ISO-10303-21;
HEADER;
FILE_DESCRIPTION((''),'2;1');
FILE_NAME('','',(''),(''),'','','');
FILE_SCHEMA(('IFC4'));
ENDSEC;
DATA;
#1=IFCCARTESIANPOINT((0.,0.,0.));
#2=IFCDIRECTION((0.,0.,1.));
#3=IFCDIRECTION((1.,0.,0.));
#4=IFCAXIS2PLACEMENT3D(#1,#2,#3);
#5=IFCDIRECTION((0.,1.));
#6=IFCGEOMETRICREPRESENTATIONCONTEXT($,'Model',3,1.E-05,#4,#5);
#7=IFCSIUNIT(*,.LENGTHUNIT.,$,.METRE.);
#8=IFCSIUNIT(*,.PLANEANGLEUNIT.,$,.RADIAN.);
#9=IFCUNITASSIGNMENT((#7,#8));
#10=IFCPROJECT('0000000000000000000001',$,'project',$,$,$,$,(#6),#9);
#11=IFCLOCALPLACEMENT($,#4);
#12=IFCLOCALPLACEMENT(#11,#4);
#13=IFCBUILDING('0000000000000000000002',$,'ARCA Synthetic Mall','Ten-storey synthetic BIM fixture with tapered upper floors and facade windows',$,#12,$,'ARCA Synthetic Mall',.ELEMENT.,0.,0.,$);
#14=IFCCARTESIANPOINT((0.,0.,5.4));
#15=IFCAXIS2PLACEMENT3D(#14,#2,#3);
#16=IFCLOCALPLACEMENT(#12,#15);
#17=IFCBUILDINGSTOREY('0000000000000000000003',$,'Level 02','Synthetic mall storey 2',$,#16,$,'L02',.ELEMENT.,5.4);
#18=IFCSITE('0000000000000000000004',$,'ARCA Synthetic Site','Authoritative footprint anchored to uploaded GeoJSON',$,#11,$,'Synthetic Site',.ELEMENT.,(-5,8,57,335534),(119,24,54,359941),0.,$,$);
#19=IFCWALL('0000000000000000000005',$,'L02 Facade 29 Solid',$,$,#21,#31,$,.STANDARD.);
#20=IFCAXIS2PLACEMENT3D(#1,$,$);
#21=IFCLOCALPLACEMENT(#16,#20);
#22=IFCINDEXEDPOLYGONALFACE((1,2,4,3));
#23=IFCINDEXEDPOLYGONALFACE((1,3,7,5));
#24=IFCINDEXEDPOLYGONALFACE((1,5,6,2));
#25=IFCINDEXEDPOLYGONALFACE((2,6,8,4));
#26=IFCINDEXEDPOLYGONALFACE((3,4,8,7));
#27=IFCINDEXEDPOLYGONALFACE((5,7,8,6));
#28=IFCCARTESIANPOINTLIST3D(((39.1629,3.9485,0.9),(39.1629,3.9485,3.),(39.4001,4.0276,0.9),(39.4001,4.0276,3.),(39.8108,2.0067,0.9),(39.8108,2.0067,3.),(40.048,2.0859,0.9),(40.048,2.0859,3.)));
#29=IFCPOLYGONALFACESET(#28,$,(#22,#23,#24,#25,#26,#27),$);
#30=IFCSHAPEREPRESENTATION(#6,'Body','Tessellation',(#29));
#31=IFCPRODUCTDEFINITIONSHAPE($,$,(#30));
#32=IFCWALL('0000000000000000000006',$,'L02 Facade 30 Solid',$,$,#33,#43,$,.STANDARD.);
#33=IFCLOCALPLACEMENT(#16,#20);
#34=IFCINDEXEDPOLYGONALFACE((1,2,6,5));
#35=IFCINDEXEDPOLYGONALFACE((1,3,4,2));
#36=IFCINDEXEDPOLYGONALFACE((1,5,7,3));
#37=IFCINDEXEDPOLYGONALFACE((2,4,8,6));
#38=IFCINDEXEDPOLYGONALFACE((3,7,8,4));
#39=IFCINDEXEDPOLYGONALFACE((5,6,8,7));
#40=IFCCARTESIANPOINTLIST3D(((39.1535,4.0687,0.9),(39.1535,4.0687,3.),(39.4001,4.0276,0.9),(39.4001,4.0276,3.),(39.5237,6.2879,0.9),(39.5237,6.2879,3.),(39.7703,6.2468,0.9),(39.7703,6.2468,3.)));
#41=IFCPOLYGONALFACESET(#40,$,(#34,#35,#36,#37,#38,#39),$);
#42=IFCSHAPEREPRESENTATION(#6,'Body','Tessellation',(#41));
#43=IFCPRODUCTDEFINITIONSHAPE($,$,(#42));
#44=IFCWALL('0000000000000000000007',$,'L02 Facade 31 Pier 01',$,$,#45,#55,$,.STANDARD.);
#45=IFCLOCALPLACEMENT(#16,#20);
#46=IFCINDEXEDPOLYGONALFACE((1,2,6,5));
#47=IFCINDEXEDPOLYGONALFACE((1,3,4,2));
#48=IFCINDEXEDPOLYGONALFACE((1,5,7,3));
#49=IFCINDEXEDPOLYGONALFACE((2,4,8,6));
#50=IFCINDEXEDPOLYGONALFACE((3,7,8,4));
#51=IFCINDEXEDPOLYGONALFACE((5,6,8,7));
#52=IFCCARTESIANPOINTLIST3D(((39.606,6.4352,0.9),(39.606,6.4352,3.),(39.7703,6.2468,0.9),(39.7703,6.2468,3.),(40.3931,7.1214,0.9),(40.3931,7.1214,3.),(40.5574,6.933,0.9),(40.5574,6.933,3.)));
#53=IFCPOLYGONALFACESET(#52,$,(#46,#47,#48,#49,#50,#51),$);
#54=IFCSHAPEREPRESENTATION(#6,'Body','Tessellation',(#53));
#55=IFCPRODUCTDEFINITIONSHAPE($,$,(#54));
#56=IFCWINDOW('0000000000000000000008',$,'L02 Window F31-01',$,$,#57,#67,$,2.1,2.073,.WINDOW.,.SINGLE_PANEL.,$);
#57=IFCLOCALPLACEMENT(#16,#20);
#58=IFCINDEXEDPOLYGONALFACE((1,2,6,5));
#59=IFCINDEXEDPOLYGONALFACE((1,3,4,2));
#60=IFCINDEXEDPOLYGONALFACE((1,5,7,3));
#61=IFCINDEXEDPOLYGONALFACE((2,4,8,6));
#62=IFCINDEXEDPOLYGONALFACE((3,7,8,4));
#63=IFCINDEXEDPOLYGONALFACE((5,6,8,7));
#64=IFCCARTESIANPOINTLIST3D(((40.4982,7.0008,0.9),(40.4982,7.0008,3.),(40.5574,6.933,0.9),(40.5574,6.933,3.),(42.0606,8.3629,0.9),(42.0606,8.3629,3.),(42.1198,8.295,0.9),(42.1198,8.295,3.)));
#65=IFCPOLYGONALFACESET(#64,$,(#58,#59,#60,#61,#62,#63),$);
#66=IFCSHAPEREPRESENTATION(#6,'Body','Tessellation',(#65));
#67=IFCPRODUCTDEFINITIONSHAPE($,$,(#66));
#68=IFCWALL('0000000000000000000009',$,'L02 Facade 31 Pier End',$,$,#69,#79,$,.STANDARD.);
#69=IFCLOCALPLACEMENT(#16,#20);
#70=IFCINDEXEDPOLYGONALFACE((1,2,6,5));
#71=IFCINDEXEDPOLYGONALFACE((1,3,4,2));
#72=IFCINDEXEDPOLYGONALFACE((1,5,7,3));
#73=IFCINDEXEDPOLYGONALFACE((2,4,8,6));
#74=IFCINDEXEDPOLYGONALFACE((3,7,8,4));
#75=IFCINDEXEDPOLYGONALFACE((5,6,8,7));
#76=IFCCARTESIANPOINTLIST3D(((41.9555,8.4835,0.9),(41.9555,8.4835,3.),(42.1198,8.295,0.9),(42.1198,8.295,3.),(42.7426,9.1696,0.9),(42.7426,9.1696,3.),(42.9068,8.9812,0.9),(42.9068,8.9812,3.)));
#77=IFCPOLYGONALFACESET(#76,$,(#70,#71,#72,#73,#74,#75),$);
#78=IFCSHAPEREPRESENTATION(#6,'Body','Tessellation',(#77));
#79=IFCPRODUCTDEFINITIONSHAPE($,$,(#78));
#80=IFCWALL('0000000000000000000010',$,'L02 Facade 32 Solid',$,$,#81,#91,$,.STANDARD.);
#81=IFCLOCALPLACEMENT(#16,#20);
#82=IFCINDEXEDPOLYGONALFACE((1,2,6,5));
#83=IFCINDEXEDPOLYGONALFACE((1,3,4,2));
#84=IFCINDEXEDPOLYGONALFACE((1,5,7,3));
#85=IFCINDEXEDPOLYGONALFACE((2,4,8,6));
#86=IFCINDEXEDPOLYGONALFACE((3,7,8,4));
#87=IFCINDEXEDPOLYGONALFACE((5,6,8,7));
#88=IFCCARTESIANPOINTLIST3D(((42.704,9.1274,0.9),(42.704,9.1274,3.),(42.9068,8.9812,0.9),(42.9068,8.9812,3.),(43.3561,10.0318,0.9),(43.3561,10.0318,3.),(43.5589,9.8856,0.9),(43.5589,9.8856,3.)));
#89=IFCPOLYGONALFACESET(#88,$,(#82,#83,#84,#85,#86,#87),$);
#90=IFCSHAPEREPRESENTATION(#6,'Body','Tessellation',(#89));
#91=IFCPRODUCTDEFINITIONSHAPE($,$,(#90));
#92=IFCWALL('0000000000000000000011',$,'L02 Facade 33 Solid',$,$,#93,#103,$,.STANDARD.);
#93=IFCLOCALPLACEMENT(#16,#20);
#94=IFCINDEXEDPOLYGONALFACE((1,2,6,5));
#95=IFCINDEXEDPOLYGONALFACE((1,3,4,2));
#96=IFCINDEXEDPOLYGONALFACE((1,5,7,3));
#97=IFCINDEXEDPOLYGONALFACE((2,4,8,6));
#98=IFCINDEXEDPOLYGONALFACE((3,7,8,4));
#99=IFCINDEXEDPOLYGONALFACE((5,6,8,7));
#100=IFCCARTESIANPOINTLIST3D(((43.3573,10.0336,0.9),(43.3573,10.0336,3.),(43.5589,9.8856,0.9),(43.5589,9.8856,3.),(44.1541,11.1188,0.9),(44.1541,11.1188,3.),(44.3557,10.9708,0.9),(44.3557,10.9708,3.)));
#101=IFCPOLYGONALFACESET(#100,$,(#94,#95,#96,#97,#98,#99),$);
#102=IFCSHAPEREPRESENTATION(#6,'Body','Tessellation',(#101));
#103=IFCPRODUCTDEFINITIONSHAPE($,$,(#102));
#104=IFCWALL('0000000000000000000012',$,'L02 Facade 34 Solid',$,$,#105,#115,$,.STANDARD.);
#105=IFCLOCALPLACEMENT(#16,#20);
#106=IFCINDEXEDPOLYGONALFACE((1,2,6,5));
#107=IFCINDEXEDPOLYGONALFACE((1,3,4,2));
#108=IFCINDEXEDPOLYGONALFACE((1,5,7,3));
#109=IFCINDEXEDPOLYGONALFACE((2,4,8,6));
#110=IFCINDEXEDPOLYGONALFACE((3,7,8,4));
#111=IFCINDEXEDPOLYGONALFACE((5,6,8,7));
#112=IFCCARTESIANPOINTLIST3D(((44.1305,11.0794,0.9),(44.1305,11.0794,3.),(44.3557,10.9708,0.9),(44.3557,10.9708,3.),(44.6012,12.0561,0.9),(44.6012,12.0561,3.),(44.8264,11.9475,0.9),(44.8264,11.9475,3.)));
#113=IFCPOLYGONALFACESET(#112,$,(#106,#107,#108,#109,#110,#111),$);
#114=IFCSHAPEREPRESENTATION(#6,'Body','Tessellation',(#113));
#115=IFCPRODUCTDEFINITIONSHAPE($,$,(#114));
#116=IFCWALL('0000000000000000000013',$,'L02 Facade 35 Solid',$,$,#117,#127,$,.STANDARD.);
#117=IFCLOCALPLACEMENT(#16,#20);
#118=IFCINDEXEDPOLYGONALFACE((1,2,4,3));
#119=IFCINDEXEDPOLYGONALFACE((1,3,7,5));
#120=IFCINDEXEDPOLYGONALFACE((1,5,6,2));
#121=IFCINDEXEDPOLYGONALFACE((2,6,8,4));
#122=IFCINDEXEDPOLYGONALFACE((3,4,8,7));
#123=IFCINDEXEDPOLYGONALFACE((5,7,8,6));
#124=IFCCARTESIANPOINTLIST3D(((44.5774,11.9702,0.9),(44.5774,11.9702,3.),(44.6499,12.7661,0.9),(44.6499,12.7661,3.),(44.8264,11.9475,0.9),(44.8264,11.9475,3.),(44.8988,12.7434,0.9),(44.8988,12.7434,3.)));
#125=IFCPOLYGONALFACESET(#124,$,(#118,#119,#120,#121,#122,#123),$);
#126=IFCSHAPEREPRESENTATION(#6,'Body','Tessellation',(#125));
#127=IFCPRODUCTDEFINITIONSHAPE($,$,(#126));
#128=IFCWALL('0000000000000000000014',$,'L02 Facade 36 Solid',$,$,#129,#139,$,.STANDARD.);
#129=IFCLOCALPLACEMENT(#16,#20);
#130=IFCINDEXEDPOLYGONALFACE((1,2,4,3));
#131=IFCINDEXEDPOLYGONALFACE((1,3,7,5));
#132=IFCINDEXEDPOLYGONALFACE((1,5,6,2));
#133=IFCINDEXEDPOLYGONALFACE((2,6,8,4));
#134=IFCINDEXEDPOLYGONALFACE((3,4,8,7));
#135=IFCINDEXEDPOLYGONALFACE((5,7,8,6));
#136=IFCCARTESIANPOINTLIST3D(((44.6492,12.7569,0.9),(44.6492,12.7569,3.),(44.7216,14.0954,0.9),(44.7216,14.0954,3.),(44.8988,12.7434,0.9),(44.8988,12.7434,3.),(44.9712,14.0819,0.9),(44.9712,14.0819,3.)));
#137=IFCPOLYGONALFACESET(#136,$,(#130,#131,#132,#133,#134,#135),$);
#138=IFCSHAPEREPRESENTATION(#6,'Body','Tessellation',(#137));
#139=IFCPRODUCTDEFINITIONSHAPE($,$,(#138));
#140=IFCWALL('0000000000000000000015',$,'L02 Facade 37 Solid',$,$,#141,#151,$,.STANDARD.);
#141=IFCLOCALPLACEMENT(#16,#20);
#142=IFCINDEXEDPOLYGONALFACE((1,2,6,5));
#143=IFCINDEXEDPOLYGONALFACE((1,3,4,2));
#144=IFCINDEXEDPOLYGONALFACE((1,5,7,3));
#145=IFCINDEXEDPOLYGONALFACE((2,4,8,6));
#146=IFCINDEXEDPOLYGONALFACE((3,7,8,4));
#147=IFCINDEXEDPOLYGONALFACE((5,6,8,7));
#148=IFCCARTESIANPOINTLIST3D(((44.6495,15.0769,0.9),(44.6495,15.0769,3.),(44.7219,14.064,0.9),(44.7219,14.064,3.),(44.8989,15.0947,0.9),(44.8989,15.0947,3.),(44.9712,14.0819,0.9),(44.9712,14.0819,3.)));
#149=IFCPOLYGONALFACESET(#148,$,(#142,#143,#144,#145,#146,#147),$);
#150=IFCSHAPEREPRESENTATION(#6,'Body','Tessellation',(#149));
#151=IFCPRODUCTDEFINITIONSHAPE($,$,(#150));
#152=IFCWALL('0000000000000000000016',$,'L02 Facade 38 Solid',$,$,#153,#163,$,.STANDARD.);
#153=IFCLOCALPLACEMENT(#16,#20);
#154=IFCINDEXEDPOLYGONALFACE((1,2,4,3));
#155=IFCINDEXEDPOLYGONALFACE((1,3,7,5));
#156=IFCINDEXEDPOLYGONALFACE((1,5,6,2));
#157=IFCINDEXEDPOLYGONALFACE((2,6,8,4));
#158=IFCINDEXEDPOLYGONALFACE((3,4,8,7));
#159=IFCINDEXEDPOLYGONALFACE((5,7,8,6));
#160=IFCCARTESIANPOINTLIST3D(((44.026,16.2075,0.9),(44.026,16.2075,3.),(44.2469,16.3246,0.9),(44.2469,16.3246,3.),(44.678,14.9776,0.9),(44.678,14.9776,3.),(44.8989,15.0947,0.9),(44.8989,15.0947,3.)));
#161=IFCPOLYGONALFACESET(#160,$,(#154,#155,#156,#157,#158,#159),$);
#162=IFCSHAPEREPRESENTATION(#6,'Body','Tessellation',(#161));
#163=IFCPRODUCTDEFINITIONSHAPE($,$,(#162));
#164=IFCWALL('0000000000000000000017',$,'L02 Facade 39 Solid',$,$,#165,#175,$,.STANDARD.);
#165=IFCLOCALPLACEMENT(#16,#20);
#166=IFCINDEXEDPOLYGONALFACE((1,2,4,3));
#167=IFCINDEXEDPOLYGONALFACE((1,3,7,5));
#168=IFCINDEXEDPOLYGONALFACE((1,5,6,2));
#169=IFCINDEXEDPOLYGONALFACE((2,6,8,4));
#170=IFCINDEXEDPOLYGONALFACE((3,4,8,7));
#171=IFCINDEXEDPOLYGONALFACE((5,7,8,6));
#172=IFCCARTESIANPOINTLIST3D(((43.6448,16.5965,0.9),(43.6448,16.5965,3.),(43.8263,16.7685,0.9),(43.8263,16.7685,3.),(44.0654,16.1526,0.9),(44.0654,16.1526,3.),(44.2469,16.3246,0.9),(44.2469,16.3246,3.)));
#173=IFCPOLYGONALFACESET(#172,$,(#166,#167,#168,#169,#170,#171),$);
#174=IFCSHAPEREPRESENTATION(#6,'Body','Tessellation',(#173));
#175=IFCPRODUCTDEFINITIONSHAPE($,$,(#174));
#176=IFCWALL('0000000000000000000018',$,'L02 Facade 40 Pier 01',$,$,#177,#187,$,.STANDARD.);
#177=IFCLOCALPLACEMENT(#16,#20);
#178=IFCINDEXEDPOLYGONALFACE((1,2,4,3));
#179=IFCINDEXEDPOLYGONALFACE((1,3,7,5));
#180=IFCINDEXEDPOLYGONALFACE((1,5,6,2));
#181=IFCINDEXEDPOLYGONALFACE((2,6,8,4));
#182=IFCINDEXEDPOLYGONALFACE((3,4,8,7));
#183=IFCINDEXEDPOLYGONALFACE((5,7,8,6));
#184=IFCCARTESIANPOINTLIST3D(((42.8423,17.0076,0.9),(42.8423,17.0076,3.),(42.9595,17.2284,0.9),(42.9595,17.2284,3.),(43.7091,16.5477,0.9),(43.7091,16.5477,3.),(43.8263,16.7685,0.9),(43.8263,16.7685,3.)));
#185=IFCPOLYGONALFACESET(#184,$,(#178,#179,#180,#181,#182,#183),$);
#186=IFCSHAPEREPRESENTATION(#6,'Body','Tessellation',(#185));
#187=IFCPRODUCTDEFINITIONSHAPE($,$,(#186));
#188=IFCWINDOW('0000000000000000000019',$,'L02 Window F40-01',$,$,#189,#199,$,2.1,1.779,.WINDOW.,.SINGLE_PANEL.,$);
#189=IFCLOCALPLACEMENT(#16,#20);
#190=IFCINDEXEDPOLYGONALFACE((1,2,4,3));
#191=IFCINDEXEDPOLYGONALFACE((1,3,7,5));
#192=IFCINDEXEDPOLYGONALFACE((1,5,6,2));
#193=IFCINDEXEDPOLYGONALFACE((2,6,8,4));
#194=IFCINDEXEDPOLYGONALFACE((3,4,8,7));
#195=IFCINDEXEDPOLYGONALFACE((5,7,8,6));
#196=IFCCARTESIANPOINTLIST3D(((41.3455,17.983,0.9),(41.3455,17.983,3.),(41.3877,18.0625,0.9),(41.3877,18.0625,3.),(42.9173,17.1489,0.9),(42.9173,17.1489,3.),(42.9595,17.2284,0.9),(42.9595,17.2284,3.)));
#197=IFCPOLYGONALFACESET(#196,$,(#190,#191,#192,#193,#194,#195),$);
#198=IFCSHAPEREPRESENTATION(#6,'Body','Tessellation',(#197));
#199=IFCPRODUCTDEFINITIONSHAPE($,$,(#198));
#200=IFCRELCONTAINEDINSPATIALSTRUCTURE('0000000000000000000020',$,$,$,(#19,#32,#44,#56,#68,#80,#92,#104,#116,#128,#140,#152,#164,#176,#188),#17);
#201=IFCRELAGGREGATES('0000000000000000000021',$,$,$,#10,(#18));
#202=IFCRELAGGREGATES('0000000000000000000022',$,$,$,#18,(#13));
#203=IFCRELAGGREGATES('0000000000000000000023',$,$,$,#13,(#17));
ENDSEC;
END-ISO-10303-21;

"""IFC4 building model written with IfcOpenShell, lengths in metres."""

from ifc_helpers import new_model, si_unit, direction, frame, origin_with_axes, place, context, project, spatial, polyline, outline, extrude, element, save


model = new_model("IFC4")

# Units and contexts
model_context = context("Model", 3, precision=1e-05, world=origin_with_axes(), true_north=direction((0.0, 1.0)))
ifc_project = project(units=[si_unit("LENGTHUNIT", "METRE"), si_unit("PLANEANGLEUNIT", "RADIAN")], contexts=[model_context])

# Site, building, storey
site_placement = place(None, origin_with_axes())
site = spatial("IfcSite", under=ifc_project, at=site_placement, Name="ARCA Synthetic Site", Description="Authoritative footprint anchored to uploaded GeoJSON", LongName="Synthetic Site", CompositionType="ELEMENT", RefLatitude=(-5, 8, 57, 335534), RefLongitude=(119, 24, 54, 359941), RefElevation=0.0)
building_placement = place(site_placement, origin_with_axes())
building = spatial("IfcBuilding", under=site, at=building_placement, Name="ARCA Synthetic Mall", Description="Ten-storey synthetic BIM fixture with tapered upper floors and facade windows", LongName="ARCA Synthetic Mall", CompositionType="ELEMENT", ElevationOfRefHeight=0.0, ElevationOfTerrain=0.0)
storey_placement = place(building_placement, frame((0.0, 0.0, 5.4), z_axis=(0.0, 0.0, 1.0), x_axis=(1.0, 0.0, 0.0)))
storey = spatial("IfcBuildingStorey", under=building, at=storey_placement, Name="Level 02", Description="Synthetic mall storey 2", LongName="L02", CompositionType="ELEMENT", Elevation=5.4)

# Walls
wall_1_placement = place(storey_placement, frame((0.0, 0.0, 0.9), z_axis=(0.0, 0.0, 1.0), x_axis=(1.0, 0.0, 0.0)))
element("IfcWall", 1, at=wall_1_placement, inside=storey, Name="L02 Facade 29 Solid", PredefinedType="STANDARD", context=model_context, shape_type="SweptSolid", body=[
    extrude(outline(polyline([(40.048, 2.0859), (39.4001, 4.0276), (39.1629, 3.9485), (39.8108, 2.0067), (40.048, 2.0859)])), origin_with_axes(), (0.0, 0.0, 1.0), 2.1),
])
wall_2_placement = place(storey_placement, frame((0.0, 0.0, 0.9), z_axis=(0.0, 0.0, 1.0), x_axis=(1.0, 0.0, 0.0)))
element("IfcWall", 2, at=wall_2_placement, inside=storey, Name="L02 Facade 30 Solid", PredefinedType="STANDARD", context=model_context, shape_type="SweptSolid", body=[
    extrude(outline(polyline([(39.4001, 4.0276), (39.7703, 6.2468), (39.5237, 6.2879), (39.1535, 4.0687), (39.4001, 4.0276)])), origin_with_axes(), (0.0, 0.0, 1.0), 2.1),
])
wall_3_placement = place(storey_placement, frame((0.0, 0.0, 0.9), z_axis=(0.0, 0.0, 1.0), x_axis=(1.0, 0.0, 0.0)))
element("IfcWall", 3, at=wall_3_placement, inside=storey, Name="L02 Facade 31 Pier 01", PredefinedType="STANDARD", context=model_context, shape_type="SweptSolid", body=[
    extrude(outline(polyline([(39.7703, 6.2468), (40.5574, 6.933), (40.3931, 7.1214), (39.606, 6.4352), (39.7703, 6.2468)])), origin_with_axes(), (0.0, 0.0, 1.0), 2.1),
])

# Window
window_1_placement = place(storey_placement, frame((0.0, 0.0, 0.9), z_axis=(0.0, 0.0, 1.0), x_axis=(1.0, 0.0, 0.0)))
element("IfcWindow", 4, at=window_1_placement, inside=storey, Name="L02 Window F31-01", OverallHeight=2.1, OverallWidth=2.073, PartitioningType="SINGLE_PANEL", PredefinedType="WINDOW", context=model_context, shape_type="SweptSolid", body=[
    extrude(outline(polyline([(40.5574, 6.933), (42.1198, 8.295), (42.0606, 8.3629), (40.4982, 7.0008), (40.5574, 6.933)])), origin_with_axes(), (0.0, 0.0, 1.0), 2.1),
])

# Walls
wall_4_placement = place(storey_placement, frame((0.0, 0.0, 0.9), z_axis=(0.0, 0.0, 1.0), x_axis=(1.0, 0.0, 0.0)))
element("IfcWall", 5, at=wall_4_placement, inside=storey, Name="L02 Facade 31 Pier End", PredefinedType="STANDARD", context=model_context, shape_type="SweptSolid", body=[
    extrude(outline(polyline([(42.1198, 8.295), (42.9068, 8.9812), (42.7426, 9.1696), (41.9555, 8.4835), (42.1198, 8.295)])), origin_with_axes(), (0.0, 0.0, 1.0), 2.1),
])
wall_5_placement = place(storey_placement, frame((0.0, 0.0, 0.9), z_axis=(0.0, 0.0, 1.0), x_axis=(1.0, 0.0, 0.0)))
element("IfcWall", 6, at=wall_5_placement, inside=storey, Name="L02 Facade 32 Solid", PredefinedType="STANDARD", context=model_context, shape_type="SweptSolid", body=[
    extrude(outline(polyline([(42.9068, 8.9812), (43.5589, 9.8856), (43.3561, 10.0318), (42.704, 9.1274), (42.9068, 8.9812)])), origin_with_axes(), (0.0, 0.0, 1.0), 2.1),
])
wall_6_placement = place(storey_placement, frame((0.0, 0.0, 0.9), z_axis=(0.0, 0.0, 1.0), x_axis=(1.0, 0.0, 0.0)))
element("IfcWall", 7, at=wall_6_placement, inside=storey, Name="L02 Facade 33 Solid", PredefinedType="STANDARD", context=model_context, shape_type="SweptSolid", body=[
    extrude(outline(polyline([(43.5589, 9.8856), (44.3557, 10.9708), (44.1541, 11.1188), (43.3573, 10.0336), (43.5589, 9.8856)])), origin_with_axes(), (0.0, 0.0, 1.0), 2.1),
])
wall_7_placement = place(storey_placement, frame((0.0, 0.0, 0.9), z_axis=(0.0, 0.0, 1.0), x_axis=(1.0, 0.0, 0.0)))
element("IfcWall", 8, at=wall_7_placement, inside=storey, Name="L02 Facade 34 Solid", PredefinedType="STANDARD", context=model_context, shape_type="SweptSolid", body=[
    extrude(outline(polyline([(44.3557, 10.9708), (44.8264, 11.9475), (44.6012, 12.0561), (44.1305, 11.0794), (44.3557, 10.9708)])), origin_with_axes(), (0.0, 0.0, 1.0), 2.1),
])
wall_8_placement = place(storey_placement, frame((0.0, 0.0, 0.9), z_axis=(0.0, 0.0, 1.0), x_axis=(1.0, 0.0, 0.0)))
element("IfcWall", 9, at=wall_8_placement, inside=storey, Name="L02 Facade 35 Solid", PredefinedType="STANDARD", context=model_context, shape_type="SweptSolid", body=[
    extrude(outline(polyline([(44.8264, 11.9475), (44.8988, 12.7434), (44.6499, 12.7661), (44.5774, 11.9702), (44.8264, 11.9475)])), origin_with_axes(), (0.0, 0.0, 1.0), 2.1),
])
wall_9_placement = place(storey_placement, frame((0.0, 0.0, 0.9), z_axis=(0.0, 0.0, 1.0), x_axis=(1.0, 0.0, 0.0)))
element("IfcWall", 10, at=wall_9_placement, inside=storey, Name="L02 Facade 36 Solid", PredefinedType="STANDARD", context=model_context, shape_type="SweptSolid", body=[
    extrude(outline(polyline([(44.8988, 12.7434), (44.9712, 14.0819), (44.7216, 14.0954), (44.6492, 12.7569), (44.8988, 12.7434)])), origin_with_axes(), (0.0, 0.0, 1.0), 2.1),
])
wall_10_placement = place(storey_placement, frame((0.0, 0.0, 0.9), z_axis=(0.0, 0.0, 1.0), x_axis=(1.0, 0.0, 0.0)))
element("IfcWall", 11, at=wall_10_placement, inside=storey, Name="L02 Facade 37 Solid", PredefinedType="STANDARD", context=model_context, shape_type="SweptSolid", body=[
    extrude(outline(polyline([(44.9712, 14.0819), (44.8989, 15.0947), (44.6495, 15.0769), (44.7219, 14.064), (44.9712, 14.0819)])), origin_with_axes(), (0.0, 0.0, 1.0), 2.1),
])
wall_11_placement = place(storey_placement, frame((0.0, 0.0, 0.9), z_axis=(0.0, 0.0, 1.0), x_axis=(1.0, 0.0, 0.0)))
element("IfcWall", 12, at=wall_11_placement, inside=storey, Name="L02 Facade 38 Solid", PredefinedType="STANDARD", context=model_context, shape_type="SweptSolid", body=[
    extrude(outline(polyline([(44.8989, 15.0947), (44.2469, 16.3246), (44.026, 16.2075), (44.678, 14.9776), (44.8989, 15.0947)])), origin_with_axes(), (0.0, 0.0, 1.0), 2.1),
])
wall_12_placement = place(storey_placement, frame((0.0, 0.0, 0.9), z_axis=(0.0, 0.0, 1.0), x_axis=(1.0, 0.0, 0.0)))
element("IfcWall", 13, at=wall_12_placement, inside=storey, Name="L02 Facade 39 Solid", PredefinedType="STANDARD", context=model_context, shape_type="SweptSolid", body=[
    extrude(outline(polyline([(44.2469, 16.3246), (43.8263, 16.7685), (43.6448, 16.5965), (44.0654, 16.1526), (44.2469, 16.3246)])), origin_with_axes(), (0.0, 0.0, 1.0), 2.1),
])
wall_13_placement = place(storey_placement, frame((0.0, 0.0, 0.9), z_axis=(0.0, 0.0, 1.0), x_axis=(1.0, 0.0, 0.0)))
element("IfcWall", 14, at=wall_13_placement, inside=storey, Name="L02 Facade 40 Pier 01", PredefinedType="STANDARD", context=model_context, shape_type="SweptSolid", body=[
    extrude(outline(polyline([(43.8263, 16.7685), (42.9595, 17.2284), (42.8423, 17.0076), (43.7091, 16.5477), (43.8263, 16.7685)])), origin_with_axes(), (0.0, 0.0, 1.0), 2.1),
])

# Window
window_2_placement = place(storey_placement, frame((0.0, 0.0, 0.9), z_axis=(0.0, 0.0, 1.0), x_axis=(1.0, 0.0, 0.0)))
element("IfcWindow", 15, at=window_2_placement, inside=storey, Name="L02 Window F40-01", OverallHeight=2.1, OverallWidth=1.779, PartitioningType="SINGLE_PANEL", PredefinedType="WINDOW", context=model_context, shape_type="SweptSolid", body=[
    extrude(outline(polyline([(42.9595, 17.2284), (41.3877, 18.0625), (41.3455, 17.983), (42.9173, 17.1489), (42.9595, 17.2284)])), origin_with_axes(), (0.0, 0.0, 1.0), 2.1),
])

save(model, "model.ifc")
